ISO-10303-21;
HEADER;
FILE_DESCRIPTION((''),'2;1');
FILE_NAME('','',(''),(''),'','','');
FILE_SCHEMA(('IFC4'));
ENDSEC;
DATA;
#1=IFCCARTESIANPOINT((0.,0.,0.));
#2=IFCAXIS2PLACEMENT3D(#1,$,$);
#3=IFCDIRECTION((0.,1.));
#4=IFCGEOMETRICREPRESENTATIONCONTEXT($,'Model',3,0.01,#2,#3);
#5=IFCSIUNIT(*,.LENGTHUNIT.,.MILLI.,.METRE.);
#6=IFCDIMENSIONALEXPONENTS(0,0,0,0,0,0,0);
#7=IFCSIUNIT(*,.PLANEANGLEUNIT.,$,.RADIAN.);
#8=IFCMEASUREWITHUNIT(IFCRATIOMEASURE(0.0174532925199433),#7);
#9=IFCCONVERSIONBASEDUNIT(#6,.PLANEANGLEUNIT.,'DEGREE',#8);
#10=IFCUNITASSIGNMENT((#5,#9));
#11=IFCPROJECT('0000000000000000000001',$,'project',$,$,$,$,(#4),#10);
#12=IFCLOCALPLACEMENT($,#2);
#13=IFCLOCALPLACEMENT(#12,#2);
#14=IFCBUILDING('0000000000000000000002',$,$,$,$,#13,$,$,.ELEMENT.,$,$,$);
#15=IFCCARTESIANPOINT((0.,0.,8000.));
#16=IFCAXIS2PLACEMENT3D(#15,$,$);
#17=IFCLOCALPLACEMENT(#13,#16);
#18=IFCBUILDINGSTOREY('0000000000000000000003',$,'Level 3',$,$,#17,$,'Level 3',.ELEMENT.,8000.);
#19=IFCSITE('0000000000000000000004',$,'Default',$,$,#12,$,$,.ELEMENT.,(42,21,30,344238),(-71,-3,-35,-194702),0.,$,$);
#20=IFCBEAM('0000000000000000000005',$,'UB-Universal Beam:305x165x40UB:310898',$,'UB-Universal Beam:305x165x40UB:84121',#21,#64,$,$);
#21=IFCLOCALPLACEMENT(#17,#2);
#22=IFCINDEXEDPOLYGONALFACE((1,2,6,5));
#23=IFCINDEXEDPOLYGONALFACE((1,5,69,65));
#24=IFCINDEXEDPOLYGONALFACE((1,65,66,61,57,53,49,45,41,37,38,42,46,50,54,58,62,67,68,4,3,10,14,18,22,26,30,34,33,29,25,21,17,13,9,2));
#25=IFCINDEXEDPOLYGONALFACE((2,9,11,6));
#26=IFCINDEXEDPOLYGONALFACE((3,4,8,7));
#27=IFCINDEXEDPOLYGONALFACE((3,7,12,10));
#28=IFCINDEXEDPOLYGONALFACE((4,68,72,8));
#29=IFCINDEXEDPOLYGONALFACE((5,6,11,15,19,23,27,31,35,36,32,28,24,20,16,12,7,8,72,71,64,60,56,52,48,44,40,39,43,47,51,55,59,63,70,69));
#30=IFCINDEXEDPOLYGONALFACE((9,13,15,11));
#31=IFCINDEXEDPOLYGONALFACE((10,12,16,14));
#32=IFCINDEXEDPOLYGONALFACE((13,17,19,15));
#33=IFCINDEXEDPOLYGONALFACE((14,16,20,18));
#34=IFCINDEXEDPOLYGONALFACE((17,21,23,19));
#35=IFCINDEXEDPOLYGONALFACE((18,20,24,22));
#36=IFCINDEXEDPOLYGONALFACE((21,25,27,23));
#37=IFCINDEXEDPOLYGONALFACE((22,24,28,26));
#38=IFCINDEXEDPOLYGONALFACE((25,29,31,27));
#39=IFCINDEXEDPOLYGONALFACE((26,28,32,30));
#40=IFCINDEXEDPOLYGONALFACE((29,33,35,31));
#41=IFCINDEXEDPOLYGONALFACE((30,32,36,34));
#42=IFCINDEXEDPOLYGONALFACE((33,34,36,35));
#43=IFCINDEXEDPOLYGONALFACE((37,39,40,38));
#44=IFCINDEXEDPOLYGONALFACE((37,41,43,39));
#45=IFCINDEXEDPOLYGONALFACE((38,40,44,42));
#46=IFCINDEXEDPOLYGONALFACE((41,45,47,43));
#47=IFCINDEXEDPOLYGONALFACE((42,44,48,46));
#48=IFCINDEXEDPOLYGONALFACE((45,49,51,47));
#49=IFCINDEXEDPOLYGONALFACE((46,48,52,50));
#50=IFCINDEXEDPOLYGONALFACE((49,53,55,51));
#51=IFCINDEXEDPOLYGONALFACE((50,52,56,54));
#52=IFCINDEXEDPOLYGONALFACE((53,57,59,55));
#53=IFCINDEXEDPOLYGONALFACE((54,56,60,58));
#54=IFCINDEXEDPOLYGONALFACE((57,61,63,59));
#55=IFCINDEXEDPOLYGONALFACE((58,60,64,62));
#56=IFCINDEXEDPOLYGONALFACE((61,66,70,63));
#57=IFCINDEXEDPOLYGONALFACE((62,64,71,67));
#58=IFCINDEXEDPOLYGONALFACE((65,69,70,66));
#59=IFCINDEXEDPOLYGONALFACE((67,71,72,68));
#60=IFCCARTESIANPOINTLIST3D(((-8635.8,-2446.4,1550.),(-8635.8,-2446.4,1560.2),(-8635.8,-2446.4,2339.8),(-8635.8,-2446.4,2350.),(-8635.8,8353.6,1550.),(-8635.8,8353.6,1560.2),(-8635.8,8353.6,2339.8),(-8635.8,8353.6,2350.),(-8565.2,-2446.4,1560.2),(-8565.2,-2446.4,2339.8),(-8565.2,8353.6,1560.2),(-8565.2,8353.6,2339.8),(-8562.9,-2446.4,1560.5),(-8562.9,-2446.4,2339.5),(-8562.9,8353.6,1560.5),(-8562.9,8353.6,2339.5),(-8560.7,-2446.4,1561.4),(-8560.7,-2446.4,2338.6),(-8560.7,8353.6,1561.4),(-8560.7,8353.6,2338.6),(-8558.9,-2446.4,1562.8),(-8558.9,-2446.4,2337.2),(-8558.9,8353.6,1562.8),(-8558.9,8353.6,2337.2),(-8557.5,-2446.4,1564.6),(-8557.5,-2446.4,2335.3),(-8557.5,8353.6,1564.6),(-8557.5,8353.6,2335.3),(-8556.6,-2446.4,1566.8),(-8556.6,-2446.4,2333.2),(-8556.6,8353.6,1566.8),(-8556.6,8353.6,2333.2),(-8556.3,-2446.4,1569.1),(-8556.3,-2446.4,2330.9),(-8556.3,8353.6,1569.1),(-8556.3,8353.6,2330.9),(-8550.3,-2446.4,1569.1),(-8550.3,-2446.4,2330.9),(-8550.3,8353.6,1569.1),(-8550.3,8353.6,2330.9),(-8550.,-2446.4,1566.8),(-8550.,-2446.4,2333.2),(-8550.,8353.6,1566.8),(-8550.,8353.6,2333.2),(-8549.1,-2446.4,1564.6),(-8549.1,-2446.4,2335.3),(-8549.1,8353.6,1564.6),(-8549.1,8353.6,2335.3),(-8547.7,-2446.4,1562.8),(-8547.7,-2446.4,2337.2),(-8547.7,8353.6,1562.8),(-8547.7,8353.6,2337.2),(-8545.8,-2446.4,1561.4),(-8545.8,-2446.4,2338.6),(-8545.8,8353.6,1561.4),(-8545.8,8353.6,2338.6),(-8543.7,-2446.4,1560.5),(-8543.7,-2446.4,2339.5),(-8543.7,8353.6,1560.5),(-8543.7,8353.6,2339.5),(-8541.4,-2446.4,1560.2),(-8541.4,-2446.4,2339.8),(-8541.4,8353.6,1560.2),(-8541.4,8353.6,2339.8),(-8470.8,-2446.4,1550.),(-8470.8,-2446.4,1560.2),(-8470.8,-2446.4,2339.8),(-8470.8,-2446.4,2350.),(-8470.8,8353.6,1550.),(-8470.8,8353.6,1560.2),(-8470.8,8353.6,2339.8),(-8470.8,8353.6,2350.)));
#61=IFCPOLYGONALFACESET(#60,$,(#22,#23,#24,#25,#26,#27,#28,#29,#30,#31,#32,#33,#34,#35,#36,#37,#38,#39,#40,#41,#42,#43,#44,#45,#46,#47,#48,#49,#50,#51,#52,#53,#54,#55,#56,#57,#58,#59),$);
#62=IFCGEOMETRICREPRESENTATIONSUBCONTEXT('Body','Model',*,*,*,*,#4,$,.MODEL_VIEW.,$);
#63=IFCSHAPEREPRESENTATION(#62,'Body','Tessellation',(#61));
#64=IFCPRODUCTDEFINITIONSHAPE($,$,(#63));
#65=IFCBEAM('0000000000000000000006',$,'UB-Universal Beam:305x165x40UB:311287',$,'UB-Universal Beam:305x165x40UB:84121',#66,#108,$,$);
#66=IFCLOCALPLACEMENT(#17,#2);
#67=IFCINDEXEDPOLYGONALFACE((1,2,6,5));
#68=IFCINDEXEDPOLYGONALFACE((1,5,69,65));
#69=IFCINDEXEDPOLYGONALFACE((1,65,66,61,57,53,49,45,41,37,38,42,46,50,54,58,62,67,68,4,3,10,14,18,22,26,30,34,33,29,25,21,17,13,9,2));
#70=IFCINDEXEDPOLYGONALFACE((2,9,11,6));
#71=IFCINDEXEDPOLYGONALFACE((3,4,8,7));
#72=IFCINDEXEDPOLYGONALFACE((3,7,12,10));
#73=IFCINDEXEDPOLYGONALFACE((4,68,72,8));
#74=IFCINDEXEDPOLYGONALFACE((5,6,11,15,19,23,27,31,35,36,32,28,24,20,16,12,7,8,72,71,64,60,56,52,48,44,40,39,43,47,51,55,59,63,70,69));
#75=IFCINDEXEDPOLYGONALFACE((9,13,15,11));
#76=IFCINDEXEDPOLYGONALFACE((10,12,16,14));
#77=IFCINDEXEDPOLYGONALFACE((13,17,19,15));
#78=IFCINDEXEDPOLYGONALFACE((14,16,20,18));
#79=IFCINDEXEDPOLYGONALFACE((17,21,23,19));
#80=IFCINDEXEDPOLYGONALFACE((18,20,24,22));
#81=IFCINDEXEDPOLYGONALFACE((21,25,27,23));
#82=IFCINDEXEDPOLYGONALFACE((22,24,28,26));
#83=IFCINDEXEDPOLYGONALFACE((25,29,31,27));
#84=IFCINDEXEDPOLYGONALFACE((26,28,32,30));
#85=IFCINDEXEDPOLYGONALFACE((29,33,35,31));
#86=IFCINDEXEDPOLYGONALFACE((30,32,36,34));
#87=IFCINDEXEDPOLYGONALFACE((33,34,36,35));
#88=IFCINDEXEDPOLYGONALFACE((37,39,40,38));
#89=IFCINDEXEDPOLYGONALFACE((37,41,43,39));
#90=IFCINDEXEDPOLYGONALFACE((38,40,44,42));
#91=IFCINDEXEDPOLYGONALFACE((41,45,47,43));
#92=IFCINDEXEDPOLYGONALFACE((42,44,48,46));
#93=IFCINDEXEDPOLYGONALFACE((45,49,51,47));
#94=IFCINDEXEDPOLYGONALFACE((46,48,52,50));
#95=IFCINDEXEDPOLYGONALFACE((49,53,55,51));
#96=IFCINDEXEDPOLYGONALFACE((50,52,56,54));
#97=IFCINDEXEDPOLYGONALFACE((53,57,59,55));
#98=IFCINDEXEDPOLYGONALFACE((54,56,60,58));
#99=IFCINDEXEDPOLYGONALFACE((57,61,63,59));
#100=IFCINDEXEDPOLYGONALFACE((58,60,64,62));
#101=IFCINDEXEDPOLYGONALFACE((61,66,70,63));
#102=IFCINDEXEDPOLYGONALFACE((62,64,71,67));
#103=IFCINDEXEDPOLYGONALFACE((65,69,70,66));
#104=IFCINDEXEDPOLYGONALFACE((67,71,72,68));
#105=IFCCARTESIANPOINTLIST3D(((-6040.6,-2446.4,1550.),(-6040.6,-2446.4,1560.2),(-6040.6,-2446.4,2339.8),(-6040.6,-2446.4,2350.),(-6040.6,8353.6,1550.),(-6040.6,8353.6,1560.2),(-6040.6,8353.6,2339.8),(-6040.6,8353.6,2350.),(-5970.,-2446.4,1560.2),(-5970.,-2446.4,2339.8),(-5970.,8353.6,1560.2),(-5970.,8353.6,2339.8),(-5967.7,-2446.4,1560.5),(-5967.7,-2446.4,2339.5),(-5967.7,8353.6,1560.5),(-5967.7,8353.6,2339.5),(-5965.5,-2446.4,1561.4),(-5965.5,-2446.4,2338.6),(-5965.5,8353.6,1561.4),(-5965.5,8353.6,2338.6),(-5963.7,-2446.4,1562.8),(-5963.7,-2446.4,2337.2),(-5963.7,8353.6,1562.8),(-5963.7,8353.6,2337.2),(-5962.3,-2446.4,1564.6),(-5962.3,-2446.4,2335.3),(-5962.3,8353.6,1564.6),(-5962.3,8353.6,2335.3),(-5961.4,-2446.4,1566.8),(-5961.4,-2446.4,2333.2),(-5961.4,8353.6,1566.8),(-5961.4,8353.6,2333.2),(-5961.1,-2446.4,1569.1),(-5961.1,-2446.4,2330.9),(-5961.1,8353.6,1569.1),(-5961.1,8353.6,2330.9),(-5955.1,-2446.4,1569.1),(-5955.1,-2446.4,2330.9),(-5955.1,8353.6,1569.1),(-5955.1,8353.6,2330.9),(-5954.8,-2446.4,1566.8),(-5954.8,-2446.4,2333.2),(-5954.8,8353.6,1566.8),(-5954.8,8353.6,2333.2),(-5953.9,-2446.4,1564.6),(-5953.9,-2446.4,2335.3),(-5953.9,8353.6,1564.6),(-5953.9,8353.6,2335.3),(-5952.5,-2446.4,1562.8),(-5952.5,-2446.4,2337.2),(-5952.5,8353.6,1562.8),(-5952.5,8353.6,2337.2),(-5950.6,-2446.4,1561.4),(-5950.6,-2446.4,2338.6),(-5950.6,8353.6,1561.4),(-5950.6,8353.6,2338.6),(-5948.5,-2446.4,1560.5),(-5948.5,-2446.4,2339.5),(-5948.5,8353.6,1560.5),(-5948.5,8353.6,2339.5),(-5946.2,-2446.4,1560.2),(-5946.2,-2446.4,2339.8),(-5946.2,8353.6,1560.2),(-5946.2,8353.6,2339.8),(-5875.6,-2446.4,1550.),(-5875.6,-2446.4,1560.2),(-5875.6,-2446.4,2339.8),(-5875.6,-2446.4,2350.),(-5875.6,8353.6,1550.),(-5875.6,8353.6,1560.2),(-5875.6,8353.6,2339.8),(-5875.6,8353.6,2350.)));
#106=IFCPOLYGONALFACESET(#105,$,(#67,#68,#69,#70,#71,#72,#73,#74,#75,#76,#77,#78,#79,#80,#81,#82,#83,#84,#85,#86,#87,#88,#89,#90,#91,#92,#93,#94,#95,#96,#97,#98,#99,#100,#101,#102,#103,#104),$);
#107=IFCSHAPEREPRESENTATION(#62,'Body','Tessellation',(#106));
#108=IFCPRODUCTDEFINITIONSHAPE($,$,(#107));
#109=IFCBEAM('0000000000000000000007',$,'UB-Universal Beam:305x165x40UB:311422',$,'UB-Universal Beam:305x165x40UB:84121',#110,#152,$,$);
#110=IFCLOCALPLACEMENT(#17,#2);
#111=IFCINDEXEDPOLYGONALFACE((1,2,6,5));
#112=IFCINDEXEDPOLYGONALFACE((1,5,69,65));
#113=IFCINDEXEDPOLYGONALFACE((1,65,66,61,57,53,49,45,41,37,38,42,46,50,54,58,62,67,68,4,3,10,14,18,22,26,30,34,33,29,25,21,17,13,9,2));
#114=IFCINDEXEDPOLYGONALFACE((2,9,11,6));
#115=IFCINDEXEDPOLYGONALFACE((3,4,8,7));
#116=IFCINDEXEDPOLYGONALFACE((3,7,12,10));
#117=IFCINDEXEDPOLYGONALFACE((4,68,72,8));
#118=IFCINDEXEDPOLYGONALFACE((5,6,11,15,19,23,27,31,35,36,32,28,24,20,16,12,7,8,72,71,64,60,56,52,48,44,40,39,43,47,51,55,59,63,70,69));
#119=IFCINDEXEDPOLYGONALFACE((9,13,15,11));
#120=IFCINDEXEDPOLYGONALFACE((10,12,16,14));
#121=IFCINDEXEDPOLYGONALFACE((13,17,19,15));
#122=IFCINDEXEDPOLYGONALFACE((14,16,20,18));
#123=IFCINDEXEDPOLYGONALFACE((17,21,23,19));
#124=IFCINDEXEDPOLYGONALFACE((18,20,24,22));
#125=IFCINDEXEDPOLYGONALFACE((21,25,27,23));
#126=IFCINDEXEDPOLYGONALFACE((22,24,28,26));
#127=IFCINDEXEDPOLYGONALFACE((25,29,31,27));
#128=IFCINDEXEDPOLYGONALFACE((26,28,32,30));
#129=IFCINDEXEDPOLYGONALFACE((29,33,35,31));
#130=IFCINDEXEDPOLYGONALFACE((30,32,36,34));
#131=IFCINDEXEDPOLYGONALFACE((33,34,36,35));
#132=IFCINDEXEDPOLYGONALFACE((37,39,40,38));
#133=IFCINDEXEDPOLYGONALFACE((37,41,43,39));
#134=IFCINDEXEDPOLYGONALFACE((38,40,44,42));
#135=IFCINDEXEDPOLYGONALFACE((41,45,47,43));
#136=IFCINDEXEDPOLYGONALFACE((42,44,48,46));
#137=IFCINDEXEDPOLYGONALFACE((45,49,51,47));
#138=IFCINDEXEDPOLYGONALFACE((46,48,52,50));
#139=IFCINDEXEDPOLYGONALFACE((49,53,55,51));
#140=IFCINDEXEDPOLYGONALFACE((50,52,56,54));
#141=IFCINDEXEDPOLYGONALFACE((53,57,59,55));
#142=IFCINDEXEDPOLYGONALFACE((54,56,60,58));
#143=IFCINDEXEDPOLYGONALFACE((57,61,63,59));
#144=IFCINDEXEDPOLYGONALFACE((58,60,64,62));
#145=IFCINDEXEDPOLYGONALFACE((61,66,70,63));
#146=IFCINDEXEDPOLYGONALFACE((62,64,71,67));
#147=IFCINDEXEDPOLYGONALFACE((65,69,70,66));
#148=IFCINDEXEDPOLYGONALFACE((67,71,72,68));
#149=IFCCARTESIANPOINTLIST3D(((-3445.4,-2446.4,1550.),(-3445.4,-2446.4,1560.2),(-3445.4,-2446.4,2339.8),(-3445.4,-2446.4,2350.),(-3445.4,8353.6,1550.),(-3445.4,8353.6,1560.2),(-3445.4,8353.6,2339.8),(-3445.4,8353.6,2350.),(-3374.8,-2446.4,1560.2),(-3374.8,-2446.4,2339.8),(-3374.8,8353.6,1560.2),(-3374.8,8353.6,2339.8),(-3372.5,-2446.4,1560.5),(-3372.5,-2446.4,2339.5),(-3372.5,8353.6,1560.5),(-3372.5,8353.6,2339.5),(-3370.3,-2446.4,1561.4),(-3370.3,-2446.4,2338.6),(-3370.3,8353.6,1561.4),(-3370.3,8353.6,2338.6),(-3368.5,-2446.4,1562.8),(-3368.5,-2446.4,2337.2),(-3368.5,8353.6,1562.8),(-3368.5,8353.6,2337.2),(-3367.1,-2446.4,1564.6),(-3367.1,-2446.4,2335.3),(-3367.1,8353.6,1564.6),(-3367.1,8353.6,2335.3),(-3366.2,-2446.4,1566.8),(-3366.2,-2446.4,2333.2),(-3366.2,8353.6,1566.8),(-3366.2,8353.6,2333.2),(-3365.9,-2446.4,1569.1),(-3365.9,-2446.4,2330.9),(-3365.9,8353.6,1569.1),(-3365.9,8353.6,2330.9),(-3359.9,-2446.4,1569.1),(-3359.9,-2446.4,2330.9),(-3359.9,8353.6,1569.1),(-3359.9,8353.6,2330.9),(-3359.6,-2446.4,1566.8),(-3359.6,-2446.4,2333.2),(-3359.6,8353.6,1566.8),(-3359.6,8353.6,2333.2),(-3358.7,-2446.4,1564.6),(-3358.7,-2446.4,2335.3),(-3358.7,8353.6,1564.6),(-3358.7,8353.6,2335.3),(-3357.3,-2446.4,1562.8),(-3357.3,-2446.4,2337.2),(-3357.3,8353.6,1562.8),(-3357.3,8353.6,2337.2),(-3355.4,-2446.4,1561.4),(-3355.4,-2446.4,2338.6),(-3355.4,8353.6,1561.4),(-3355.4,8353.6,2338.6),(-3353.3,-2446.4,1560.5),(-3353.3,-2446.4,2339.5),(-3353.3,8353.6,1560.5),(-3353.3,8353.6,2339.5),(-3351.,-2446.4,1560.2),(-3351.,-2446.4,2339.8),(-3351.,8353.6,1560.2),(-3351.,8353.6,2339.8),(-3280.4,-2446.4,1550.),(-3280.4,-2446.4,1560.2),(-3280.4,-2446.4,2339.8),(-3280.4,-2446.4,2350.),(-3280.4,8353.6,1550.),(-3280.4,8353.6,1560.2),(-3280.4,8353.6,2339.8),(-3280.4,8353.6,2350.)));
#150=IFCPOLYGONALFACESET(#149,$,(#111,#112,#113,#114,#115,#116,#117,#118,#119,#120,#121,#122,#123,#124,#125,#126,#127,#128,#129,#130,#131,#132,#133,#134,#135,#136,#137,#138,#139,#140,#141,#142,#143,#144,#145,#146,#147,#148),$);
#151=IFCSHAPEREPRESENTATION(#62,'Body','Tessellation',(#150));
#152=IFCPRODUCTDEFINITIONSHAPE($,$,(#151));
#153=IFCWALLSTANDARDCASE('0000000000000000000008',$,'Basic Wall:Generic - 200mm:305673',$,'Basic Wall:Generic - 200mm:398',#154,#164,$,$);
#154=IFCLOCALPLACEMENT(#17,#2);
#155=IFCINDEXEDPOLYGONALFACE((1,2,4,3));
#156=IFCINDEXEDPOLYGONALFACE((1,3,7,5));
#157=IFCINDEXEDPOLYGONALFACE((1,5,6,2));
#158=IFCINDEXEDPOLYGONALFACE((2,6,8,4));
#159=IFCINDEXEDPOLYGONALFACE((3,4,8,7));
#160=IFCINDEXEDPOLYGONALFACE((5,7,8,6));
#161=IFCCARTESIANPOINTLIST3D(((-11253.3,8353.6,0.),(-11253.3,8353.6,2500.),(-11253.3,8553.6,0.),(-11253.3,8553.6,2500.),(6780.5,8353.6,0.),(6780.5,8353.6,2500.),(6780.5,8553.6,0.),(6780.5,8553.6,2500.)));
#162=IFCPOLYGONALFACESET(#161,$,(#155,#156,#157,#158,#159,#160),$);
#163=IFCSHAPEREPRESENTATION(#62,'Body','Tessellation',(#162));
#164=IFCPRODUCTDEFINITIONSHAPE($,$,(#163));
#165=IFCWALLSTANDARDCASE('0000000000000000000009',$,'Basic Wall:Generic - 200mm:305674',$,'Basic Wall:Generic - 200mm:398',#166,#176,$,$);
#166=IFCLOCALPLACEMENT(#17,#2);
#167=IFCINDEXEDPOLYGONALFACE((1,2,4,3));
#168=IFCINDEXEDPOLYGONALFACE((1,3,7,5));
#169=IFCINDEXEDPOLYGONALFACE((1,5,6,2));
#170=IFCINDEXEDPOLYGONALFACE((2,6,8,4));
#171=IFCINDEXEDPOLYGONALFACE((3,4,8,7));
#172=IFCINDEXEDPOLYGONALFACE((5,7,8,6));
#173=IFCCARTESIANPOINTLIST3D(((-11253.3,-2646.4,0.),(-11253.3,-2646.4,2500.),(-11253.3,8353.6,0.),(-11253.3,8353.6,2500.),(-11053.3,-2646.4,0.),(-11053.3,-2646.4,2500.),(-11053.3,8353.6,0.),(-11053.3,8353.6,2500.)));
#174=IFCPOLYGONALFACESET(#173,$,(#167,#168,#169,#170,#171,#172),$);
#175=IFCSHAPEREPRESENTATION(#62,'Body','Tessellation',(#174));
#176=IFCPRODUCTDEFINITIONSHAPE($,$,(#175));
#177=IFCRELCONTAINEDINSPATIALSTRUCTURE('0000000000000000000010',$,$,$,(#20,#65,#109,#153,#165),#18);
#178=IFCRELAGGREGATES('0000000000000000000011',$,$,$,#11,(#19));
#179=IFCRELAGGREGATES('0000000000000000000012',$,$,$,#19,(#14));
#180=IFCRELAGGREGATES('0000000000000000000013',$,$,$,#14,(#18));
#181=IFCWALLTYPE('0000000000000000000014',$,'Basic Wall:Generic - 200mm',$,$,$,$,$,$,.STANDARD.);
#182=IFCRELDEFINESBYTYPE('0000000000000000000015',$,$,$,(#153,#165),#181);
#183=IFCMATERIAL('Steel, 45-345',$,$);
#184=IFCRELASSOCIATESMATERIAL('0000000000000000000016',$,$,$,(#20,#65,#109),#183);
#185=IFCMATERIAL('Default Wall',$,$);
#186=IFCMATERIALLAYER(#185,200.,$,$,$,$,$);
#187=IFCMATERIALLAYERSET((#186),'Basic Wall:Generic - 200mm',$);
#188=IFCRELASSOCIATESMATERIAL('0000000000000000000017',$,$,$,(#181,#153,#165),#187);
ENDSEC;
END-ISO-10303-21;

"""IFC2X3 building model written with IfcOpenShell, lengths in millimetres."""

from ifc_helpers import new_model, entity, si_unit, converted_unit, direction, frame, frame_2d, origin, place, context, subcontext, project, spatial, rectangle, i_section, extrude, clip, halfspace, material, layer, layer_set, layer_usage, type_object, element, save


model = new_model("IFC2X3")

# Units and contexts
model_context = context("Model", 3, precision=0.01, world=origin(), true_north=direction((0.0, 1.0)))
body_context = subcontext(model_context, "Body", "Model", "MODEL_VIEW")
ifc_project = project(units=[si_unit("LENGTHUNIT", "METRE", prefix="MILLI"), converted_unit("PLANEANGLEUNIT", "DEGREE", entity("IfcRatioMeasure", 0.0174532925199433), si_unit("PLANEANGLEUNIT", "RADIAN"), dimensions=[0, 0, 0, 0, 0, 0, 0])], contexts=[model_context])

# Site, building, storey
site_placement = place(None, origin())
site = spatial("IfcSite", under=ifc_project, at=site_placement, Name="Default", CompositionType="ELEMENT", RefLatitude=(42, 21, 30, 344238), RefLongitude=(-71, -3, -35, -194702), RefElevation=0.0)
building_placement = place(site_placement, origin())
building = spatial("IfcBuilding", under=site, at=building_placement, CompositionType="ELEMENT")
storey_placement = place(building_placement, frame((0.0, 0.0, 8000.0)))
storey = spatial("IfcBuildingStorey", under=building, at=storey_placement, Name="Level 3", LongName="Level 3", CompositionType="ELEMENT", Elevation=8000.0)

# Beams
ifc_material_1 = material(Name="Steel, 45-345")
for number, where, z_axis, x_axis, name in (
    (1, (-8553.3, 8353.6, 2350.0), (0.0, 0.0, 1.0), (0.0, -1.0, 0.0), "UB-Universal Beam:305x165x40UB:310898"),
    (2, (-5958.1, 8353.6, 2350.0), (0.0, 0.0, 1.0), (0.0, -1.0, 0.0), "UB-Universal Beam:305x165x40UB:311287"),
):
    element("IfcBeam", number, at=place(storey_placement, frame(where, z_axis=z_axis, x_axis=x_axis)), inside=storey, material=ifc_material_1, Name=name, ObjectType="UB-Universal Beam:305x165x40UB:84121", context=body_context, shape_type="SweptSolid", body=[
        extrude(i_section(OverallWidth=165.0, OverallDepth=800.0, WebThickness=6.0, FlangeThickness=10.2, FilletRadius=8.9, at=frame_2d((0.0, 0.0), x_axis=(0.0, 1.0))), frame((0.0, 0.0, -400.0), z_axis=(1.0, 0.0, 0.0), x_axis=(0.0, 0.0, -1.0)), (0.0, 0.0, 1.0), 10800.0),
    ])
beam_placement = place(storey_placement, frame((-3362.9, 8353.6, 2350.0), z_axis=(0.0, 0.0, 1.0), x_axis=(0.0, -1.0, 0.0)))
element("IfcBeam", 3, at=beam_placement, inside=storey, material=ifc_material_1, Name="UB-Universal Beam:305x165x40UB:311422", ObjectType="UB-Universal Beam:305x165x40UB:84121", context=body_context, shape_type="SweptSolid", body=[
    extrude(i_section(OverallWidth=165.0, OverallDepth=800.0, WebThickness=6.0, FlangeThickness=10.2, FilletRadius=8.9, at=frame_2d((0.0, 0.0), x_axis=(0.0, 1.0))), frame((0.0, 0.0, -400.0), z_axis=(1.0, 0.0, 0.0), x_axis=(0.0, 0.0, -1.0)), (0.0, 0.0, 1.0), 10800.0),
])

# Walls
ifc_material_2 = material(Name="Default Wall")
ifc_layer = layer(ifc_material_2, 200.0)
ifc_layer_set = layer_set([ifc_layer], Name="Basic Wall:Generic - 200mm")
ifc_layer_usage_1 = layer_usage(ifc_layer_set, "AXIS2", "NEGATIVE", 100.0)
wall_type = type_object("IfcWallType", Name="Basic Wall:Generic - 200mm", PredefinedType="STANDARD", material=ifc_layer_set)
wall_1_placement = place(storey_placement, frame((-11253.3, 8453.6, 0.0)))
element("IfcWallStandardCase", 4, at=wall_1_placement, inside=storey, type_object=wall_type, material=ifc_layer_usage_1, Name="Basic Wall:Generic - 200mm:305673", ObjectType="Basic Wall:Generic - 200mm:398", context=body_context, shape_type="Clipping", body=[
    clip(extrude(rectangle(XDim=18033.8, YDim=200.0, at=frame_2d((9016.9, 0.0), x_axis=(-1.0, 0.0))), origin(), (0.0, 0.0, 1.0), 2500.0), halfspace(frame((0.0, 0.0, -8000.0)), True)),
])
ifc_layer_usage_2 = layer_usage(ifc_layer_set, "AXIS2", "NEGATIVE", 100.0)
wall_2_placement = place(storey_placement, frame((-11153.3, -2646.4, 0.0), z_axis=(0.0, 0.0, 1.0), x_axis=(0.0, 1.0, 0.0)))
element("IfcWallStandardCase", 5, at=wall_2_placement, inside=storey, type_object=wall_type, material=ifc_layer_usage_2, Name="Basic Wall:Generic - 200mm:305674", ObjectType="Basic Wall:Generic - 200mm:398", context=body_context, shape_type="Clipping", body=[
    clip(extrude(rectangle(XDim=11000.0, YDim=200.0, at=frame_2d((5500.0, 0.0), x_axis=(-1.0, 0.0))), origin(), (0.0, 0.0, 1.0), 2500.0), halfspace(frame((0.0, 0.0, -8000.0)), True)),
])

save(model, "model.ifc")
